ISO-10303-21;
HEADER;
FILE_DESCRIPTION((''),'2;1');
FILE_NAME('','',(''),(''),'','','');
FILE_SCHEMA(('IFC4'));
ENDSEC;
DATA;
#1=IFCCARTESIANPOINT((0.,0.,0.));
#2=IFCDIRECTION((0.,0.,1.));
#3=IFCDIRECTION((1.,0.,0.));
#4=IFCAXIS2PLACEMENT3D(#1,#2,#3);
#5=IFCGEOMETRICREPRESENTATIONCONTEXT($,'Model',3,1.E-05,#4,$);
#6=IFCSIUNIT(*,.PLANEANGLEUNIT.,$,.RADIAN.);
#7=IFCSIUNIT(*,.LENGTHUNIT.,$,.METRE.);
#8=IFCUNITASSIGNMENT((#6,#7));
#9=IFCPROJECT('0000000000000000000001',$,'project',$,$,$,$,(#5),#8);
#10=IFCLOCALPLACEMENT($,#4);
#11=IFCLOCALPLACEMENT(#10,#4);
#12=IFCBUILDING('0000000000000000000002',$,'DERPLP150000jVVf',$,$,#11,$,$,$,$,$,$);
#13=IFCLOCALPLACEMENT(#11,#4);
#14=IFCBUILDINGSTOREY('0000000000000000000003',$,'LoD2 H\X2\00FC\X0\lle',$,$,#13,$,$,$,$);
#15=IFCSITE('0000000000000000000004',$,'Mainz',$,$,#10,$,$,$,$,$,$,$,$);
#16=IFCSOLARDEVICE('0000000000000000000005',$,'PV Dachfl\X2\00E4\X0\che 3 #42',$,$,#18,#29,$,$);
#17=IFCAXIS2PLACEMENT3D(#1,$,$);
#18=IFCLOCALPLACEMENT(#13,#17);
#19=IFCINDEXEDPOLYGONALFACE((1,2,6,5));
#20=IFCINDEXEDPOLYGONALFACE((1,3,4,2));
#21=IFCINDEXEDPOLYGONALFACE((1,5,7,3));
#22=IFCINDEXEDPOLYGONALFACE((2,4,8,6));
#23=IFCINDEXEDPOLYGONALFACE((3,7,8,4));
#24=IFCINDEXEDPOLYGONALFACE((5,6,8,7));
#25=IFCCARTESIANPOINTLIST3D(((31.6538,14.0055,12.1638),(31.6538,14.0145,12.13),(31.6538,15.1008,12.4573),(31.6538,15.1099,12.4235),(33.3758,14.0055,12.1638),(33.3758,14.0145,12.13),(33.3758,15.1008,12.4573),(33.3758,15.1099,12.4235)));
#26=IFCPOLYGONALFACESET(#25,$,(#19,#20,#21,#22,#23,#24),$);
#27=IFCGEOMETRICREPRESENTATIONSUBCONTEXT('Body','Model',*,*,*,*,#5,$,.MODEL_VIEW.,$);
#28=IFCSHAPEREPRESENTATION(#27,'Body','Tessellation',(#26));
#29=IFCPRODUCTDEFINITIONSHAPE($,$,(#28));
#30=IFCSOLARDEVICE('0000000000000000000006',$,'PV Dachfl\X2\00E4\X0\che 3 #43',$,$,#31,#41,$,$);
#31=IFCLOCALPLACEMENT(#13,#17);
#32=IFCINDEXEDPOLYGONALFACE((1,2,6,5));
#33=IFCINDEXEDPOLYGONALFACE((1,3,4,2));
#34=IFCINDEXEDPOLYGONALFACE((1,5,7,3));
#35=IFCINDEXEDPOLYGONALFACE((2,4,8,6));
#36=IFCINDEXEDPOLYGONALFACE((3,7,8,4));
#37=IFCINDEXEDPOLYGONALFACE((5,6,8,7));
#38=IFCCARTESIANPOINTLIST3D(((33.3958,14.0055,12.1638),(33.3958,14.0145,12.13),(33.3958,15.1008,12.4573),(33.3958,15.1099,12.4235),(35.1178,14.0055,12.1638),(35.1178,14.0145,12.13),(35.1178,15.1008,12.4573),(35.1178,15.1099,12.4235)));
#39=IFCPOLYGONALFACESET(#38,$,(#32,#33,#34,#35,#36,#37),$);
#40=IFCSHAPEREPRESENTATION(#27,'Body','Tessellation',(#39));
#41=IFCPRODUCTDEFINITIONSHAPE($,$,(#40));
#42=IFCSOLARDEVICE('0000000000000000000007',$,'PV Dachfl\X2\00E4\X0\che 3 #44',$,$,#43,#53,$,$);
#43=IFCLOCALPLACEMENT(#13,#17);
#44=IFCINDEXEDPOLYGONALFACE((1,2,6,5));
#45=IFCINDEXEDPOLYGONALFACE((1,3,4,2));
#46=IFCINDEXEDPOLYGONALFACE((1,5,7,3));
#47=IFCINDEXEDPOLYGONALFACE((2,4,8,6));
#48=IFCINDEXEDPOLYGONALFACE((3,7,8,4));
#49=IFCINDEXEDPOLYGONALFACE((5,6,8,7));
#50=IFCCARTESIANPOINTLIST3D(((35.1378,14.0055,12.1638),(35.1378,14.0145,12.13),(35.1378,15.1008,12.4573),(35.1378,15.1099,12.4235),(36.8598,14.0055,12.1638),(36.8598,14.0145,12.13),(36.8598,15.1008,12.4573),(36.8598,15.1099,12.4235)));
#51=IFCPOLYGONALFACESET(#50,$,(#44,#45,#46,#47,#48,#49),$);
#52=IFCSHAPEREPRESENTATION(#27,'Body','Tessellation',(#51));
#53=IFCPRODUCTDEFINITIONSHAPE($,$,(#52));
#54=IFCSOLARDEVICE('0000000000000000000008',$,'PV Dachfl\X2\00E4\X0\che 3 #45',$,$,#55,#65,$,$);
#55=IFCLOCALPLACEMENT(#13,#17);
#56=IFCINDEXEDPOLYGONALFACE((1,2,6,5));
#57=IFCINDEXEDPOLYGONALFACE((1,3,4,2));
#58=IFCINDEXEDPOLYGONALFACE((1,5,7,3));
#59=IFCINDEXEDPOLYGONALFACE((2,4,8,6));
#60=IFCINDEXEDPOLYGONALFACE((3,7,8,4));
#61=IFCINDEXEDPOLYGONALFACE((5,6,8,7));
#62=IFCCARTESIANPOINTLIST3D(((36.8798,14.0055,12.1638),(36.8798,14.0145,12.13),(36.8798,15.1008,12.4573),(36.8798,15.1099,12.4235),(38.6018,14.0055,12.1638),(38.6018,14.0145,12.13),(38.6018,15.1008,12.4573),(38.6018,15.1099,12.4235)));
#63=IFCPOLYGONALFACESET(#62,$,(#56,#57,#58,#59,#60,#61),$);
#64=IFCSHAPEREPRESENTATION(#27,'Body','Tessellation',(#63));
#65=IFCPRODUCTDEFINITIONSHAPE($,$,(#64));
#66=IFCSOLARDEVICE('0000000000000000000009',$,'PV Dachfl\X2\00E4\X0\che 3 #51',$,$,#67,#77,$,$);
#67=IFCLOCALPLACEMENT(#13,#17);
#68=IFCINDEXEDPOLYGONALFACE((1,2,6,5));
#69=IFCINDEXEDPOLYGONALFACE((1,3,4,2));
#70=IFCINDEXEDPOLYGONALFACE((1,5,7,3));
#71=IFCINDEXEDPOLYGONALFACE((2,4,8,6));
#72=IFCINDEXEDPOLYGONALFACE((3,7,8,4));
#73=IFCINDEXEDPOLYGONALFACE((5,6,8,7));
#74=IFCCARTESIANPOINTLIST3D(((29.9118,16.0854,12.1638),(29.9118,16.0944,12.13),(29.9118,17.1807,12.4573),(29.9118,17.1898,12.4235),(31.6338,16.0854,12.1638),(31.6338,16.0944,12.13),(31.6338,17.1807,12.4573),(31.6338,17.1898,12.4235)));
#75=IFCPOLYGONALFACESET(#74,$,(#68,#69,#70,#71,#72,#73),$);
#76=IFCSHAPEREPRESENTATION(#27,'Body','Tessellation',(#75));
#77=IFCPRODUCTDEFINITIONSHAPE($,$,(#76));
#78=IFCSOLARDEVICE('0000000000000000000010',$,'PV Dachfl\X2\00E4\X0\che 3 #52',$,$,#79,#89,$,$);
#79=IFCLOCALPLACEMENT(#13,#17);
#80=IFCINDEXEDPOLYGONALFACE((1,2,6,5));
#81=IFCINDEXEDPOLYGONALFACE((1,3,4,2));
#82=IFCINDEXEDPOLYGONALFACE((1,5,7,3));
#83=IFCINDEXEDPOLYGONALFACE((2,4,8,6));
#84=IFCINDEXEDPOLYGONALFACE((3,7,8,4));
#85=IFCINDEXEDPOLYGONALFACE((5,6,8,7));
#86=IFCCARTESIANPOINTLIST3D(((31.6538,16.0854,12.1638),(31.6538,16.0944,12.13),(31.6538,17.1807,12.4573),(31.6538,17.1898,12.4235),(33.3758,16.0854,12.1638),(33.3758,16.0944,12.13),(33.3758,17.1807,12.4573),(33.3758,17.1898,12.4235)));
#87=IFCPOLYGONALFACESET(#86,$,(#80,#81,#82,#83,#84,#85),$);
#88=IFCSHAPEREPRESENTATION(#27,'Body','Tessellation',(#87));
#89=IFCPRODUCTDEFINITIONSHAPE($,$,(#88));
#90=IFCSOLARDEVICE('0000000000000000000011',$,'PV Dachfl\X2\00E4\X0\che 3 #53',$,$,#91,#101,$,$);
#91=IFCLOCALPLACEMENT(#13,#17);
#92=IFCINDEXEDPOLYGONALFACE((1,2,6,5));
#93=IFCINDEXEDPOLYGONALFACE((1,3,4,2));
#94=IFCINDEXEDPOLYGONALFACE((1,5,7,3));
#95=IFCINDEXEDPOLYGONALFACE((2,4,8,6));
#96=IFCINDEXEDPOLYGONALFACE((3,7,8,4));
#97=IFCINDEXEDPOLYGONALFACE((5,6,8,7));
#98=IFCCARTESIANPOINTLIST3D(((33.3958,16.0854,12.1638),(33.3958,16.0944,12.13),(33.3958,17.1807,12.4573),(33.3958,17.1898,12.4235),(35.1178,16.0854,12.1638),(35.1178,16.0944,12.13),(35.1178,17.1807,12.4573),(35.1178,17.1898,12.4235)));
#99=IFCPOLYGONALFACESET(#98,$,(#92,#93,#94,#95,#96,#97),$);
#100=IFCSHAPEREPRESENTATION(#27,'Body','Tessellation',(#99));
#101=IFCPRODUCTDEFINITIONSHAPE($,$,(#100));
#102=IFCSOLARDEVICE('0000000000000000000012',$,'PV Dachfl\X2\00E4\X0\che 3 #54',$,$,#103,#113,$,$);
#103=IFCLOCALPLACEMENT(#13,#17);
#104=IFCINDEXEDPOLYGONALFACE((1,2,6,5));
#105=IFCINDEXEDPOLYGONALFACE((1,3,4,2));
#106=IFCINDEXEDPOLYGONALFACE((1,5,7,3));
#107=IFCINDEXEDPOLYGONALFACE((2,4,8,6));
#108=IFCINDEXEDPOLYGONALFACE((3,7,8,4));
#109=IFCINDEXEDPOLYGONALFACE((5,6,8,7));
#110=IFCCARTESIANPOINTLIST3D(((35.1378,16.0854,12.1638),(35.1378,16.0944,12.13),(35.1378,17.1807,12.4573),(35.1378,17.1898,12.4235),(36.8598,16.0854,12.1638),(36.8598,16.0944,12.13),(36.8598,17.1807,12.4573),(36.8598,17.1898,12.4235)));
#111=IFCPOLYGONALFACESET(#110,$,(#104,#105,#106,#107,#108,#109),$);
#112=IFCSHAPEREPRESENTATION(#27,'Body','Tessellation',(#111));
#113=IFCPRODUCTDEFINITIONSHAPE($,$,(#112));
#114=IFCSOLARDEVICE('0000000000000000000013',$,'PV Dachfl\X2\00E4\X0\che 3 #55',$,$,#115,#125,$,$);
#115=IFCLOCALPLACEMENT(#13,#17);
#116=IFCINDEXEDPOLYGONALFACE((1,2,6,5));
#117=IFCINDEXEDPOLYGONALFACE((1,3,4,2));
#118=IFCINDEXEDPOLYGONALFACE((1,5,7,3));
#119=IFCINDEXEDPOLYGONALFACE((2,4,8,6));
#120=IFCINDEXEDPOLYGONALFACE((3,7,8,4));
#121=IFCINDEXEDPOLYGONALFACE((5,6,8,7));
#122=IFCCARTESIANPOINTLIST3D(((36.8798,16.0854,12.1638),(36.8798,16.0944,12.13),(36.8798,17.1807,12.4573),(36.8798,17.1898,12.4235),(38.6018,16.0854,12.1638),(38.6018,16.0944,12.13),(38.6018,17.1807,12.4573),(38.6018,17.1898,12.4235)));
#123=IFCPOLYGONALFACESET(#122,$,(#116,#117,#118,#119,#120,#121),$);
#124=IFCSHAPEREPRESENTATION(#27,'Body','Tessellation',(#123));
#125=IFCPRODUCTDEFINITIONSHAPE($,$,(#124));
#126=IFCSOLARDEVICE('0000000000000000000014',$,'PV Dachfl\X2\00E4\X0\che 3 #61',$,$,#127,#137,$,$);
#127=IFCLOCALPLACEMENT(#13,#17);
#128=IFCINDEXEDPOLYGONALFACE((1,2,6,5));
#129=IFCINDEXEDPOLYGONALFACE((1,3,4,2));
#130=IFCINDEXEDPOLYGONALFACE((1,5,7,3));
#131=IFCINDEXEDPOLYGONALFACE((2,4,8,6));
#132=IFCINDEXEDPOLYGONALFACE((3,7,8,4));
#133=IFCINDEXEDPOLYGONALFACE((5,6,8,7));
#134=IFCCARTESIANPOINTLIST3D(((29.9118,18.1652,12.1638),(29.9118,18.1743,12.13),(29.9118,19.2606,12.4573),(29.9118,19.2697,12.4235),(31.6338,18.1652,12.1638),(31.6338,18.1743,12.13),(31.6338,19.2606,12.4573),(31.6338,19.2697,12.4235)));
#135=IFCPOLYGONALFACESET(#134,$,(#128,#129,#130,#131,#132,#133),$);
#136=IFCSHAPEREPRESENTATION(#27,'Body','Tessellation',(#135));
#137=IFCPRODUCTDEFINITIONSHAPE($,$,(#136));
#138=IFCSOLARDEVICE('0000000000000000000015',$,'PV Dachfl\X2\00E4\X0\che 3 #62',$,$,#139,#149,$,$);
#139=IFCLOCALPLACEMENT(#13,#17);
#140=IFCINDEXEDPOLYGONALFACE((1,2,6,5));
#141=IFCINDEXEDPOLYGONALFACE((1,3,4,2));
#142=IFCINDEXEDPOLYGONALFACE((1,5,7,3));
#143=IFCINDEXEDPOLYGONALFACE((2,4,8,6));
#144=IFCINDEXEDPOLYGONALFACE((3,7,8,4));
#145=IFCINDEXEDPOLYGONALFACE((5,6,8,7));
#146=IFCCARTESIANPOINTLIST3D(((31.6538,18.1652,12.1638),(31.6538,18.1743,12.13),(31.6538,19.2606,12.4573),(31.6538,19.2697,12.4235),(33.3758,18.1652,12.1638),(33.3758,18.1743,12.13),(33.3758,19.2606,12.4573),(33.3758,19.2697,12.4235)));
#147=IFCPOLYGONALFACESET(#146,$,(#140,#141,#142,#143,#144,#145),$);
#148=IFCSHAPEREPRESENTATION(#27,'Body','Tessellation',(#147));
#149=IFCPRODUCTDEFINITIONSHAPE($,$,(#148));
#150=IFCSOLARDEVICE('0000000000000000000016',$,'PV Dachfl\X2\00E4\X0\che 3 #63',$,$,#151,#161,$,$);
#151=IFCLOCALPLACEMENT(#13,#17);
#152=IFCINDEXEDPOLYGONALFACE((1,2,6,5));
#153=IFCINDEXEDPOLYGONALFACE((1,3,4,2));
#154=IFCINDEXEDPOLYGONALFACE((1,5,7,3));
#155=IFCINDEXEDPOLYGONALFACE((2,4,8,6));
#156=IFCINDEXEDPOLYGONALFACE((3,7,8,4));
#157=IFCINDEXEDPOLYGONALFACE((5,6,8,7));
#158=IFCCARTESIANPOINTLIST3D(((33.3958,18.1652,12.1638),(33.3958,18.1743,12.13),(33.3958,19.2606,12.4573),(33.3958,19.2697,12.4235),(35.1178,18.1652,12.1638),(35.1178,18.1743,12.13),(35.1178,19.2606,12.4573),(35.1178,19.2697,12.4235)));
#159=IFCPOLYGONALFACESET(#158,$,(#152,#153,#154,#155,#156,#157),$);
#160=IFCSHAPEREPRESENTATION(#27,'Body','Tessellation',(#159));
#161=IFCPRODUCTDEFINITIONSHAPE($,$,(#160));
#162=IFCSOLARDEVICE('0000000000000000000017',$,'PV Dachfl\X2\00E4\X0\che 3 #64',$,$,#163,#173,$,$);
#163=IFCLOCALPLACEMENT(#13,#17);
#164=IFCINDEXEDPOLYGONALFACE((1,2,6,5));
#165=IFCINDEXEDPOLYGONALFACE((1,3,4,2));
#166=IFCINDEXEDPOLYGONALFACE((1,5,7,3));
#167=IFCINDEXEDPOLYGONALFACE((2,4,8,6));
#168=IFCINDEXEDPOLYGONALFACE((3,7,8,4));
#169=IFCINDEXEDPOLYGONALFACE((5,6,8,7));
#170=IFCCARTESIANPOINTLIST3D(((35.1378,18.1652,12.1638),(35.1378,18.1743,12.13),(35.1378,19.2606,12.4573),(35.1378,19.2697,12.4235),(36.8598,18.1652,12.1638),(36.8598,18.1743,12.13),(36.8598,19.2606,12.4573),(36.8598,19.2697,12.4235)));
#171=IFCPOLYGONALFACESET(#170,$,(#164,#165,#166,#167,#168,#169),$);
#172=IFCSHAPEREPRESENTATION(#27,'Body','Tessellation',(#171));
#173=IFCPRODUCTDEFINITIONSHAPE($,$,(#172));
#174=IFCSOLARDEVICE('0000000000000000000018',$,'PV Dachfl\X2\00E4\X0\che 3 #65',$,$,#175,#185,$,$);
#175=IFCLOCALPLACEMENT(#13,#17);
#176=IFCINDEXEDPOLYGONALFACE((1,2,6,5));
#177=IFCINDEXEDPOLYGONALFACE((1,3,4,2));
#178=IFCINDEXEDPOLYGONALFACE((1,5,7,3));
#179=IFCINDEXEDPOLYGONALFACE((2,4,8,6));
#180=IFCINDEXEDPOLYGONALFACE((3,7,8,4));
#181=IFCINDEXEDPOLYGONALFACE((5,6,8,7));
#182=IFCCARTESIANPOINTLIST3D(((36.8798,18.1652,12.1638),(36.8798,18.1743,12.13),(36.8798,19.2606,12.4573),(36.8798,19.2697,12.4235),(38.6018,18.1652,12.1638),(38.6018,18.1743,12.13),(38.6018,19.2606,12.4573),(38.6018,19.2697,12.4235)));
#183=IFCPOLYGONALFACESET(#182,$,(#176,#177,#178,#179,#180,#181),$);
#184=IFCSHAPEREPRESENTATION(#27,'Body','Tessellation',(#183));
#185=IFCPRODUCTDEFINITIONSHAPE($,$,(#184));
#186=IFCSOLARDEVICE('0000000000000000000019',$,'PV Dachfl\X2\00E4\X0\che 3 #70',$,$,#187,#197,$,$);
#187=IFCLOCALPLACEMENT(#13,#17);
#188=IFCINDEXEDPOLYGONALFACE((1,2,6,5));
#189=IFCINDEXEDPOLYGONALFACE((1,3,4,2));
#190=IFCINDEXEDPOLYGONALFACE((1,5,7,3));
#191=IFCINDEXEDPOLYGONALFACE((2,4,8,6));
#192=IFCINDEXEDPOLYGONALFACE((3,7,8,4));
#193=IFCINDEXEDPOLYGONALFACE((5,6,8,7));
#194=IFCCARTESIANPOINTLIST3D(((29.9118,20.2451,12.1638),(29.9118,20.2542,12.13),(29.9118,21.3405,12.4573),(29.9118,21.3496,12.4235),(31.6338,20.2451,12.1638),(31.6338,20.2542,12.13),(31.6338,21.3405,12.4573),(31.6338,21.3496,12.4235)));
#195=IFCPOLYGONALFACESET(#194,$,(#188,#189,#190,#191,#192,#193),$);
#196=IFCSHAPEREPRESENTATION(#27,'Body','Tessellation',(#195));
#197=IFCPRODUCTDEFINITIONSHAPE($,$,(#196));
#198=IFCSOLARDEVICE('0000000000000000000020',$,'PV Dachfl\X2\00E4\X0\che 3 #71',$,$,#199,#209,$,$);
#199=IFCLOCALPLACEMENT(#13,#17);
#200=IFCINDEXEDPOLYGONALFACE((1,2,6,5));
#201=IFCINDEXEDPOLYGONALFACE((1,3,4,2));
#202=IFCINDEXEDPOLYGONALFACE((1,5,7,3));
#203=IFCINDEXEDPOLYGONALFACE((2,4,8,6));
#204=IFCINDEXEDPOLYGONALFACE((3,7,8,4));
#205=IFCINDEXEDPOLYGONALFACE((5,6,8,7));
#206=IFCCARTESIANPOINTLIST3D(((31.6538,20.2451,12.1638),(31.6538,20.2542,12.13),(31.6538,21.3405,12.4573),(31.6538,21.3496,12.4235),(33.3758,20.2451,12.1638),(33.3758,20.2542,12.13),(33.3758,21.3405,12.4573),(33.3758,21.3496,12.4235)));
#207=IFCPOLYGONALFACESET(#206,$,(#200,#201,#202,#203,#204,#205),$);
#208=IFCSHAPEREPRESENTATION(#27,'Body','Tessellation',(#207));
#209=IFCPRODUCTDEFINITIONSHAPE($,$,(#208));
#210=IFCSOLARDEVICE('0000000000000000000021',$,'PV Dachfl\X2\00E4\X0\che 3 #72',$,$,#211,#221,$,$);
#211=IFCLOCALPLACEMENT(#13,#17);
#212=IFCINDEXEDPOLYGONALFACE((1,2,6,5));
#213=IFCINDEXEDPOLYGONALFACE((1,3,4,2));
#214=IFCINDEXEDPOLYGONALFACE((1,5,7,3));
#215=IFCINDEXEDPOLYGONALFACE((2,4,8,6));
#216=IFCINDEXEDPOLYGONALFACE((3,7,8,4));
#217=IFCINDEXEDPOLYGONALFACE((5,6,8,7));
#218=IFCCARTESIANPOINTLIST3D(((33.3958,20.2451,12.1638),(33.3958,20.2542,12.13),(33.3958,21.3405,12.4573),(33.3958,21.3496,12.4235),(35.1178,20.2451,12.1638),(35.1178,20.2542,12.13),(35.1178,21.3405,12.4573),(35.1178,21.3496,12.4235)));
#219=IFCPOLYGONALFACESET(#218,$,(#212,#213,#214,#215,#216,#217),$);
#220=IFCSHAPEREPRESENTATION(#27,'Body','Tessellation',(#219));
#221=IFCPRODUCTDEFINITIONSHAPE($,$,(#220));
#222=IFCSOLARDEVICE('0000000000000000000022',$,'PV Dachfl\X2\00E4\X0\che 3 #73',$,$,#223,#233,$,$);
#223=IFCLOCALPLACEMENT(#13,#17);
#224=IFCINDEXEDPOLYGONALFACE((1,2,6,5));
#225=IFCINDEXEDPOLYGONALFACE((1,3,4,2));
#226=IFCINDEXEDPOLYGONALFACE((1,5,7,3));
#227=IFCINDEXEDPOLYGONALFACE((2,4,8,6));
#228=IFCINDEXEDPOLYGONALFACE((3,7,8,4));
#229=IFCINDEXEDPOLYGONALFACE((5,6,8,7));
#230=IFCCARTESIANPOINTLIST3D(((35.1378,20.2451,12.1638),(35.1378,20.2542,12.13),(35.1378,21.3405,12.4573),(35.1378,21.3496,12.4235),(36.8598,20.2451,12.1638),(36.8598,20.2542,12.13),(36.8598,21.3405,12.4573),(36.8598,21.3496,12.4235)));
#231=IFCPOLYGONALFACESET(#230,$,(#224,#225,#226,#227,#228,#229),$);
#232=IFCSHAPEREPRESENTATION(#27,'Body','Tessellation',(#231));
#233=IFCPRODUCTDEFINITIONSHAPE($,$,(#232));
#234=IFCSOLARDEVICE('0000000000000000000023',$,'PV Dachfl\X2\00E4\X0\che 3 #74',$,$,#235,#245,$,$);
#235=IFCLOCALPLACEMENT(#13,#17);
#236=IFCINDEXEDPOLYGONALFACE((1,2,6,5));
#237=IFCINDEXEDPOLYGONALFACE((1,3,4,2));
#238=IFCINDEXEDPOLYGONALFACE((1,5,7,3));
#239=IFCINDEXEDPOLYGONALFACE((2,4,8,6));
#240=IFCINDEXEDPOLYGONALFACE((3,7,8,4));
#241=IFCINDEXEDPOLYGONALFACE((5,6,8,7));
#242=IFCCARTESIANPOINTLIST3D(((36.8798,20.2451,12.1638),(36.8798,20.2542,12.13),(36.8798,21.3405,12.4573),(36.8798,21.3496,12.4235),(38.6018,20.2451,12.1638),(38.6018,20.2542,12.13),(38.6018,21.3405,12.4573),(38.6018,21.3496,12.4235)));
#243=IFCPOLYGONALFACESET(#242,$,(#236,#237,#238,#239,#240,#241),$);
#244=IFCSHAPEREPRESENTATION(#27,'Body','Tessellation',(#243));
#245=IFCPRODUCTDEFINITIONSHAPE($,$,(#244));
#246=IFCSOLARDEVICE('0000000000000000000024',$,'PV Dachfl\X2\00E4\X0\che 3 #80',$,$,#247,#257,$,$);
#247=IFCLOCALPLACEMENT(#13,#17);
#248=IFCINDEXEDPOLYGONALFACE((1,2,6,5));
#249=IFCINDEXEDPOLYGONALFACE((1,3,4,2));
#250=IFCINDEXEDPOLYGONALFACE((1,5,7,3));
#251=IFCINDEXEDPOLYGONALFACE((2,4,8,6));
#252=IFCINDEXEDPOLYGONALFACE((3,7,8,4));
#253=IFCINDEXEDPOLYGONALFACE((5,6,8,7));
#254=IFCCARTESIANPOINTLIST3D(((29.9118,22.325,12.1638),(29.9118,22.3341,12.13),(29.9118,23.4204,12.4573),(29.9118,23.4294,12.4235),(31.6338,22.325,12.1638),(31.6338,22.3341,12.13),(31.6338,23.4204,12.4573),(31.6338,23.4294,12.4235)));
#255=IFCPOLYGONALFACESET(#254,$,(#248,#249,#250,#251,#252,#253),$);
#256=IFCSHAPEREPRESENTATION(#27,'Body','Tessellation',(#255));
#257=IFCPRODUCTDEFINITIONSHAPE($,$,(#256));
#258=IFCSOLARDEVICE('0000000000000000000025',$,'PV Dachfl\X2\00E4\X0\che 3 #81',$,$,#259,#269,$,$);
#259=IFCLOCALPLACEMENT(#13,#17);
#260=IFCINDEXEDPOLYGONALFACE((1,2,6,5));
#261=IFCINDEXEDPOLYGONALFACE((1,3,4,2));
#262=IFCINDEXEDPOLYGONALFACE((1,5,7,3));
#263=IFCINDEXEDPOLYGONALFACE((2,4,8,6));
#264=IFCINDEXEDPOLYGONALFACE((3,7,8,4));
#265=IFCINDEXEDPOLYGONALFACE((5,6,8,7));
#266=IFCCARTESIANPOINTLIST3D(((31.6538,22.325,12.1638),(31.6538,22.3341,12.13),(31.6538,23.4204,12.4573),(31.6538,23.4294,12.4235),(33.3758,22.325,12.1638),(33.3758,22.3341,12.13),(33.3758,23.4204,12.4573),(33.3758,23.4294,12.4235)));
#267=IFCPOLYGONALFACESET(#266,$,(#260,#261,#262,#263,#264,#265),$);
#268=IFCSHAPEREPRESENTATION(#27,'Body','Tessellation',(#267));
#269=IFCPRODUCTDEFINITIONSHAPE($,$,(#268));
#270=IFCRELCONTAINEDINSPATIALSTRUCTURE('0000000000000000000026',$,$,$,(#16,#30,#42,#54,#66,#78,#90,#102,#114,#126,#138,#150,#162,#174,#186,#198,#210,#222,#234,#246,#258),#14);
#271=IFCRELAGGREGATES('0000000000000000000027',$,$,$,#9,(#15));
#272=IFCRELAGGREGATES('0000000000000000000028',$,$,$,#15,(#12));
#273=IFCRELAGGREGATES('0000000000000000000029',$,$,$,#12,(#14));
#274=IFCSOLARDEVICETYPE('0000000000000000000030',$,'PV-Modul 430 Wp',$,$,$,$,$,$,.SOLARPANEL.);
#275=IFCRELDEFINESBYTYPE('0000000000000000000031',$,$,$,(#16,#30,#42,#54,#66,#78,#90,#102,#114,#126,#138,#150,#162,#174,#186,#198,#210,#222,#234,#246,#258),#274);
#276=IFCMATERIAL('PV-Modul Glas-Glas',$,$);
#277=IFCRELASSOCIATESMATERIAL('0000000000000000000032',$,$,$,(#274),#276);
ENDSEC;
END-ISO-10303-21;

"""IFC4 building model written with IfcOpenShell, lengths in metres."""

from ifc_helpers import new_model, si_unit, frame, frame_2d, origin, origin_with_axes, place, context, subcontext, project, spatial, rectangle, extrude, source, transform, mapped, material, type_object, type_shapes, element, save


model = new_model("IFC4")

# Units and contexts
model_context = context("Model", 3, precision=1e-05, world=origin_with_axes())
body_context = subcontext(model_context, "Body", "Model", "MODEL_VIEW")
ifc_project = project(units=[si_unit("PLANEANGLEUNIT", "RADIAN"), si_unit("LENGTHUNIT", "METRE")], contexts=[model_context])

# Site, building, storey
site_placement = place(None, origin_with_axes())
site = spatial("IfcSite", under=ifc_project, at=site_placement, Name="Mainz")
building_placement = place(site_placement, origin_with_axes())
building = spatial("IfcBuilding", under=site, at=building_placement, Name="DERPLP150000jVVf")
storey_placement = place(building_placement, origin_with_axes())
storey = spatial("IfcBuildingStorey", under=building, at=storey_placement, Name="LoD2 Hülle")

# Solar devices
ifc_material = material(Name="PV-Modul Glas-Glas")
solar_device_type = type_object("IfcSolarDeviceType", Name="PV-Modul 430 Wp", PredefinedType="SOLARPANEL", material=ifc_material)
shared_shape = source(origin_with_axes(), body_context, "Body", "SweptSolid", [
    extrude(rectangle(XDim=1.722, YDim=1.134, at=frame_2d((0.861, 0.567))), origin(), (0.0, 0.0, 1.0), 0.035),
])
type_shapes(solar_device_type, [shared_shape])
for number, where, z_axis, x_axis, name in (
    (1, (31.6538, 14.0145, 12.13), (0.0, -0.258819, 0.965926), (1.0, 0.0, 0.0), "PV Dachfläche 3 #42"),
    (2, (33.3958, 14.0145, 12.13), (0.0, -0.258819, 0.965926), (1.0, 0.0, 0.0), "PV Dachfläche 3 #43"),
    (3, (35.1378, 14.0145, 12.13), (0.0, -0.258819, 0.965926), (1.0, 0.0, 0.0), "PV Dachfläche 3 #44"),
    (4, (36.8798, 14.0145, 12.13), (0.0, -0.258819, 0.965926), (1.0, 0.0, 0.0), "PV Dachfläche 3 #45"),
    (5, (29.9118, 16.0944, 12.13), (0.0, -0.258819, 0.965926), (1.0, 0.0, 0.0), "PV Dachfläche 3 #51"),
    (6, (31.6538, 16.0944, 12.13), (0.0, -0.258819, 0.965926), (1.0, 0.0, 0.0), "PV Dachfläche 3 #52"),
    (7, (33.3958, 16.0944, 12.13), (0.0, -0.258819, 0.965926), (1.0, 0.0, 0.0), "PV Dachfläche 3 #53"),
    (8, (35.1378, 16.0944, 12.13), (0.0, -0.258819, 0.965926), (1.0, 0.0, 0.0), "PV Dachfläche 3 #54"),
    (9, (36.8798, 16.0944, 12.13), (0.0, -0.258819, 0.965926), (1.0, 0.0, 0.0), "PV Dachfläche 3 #55"),
    (10, (29.9118, 18.1743, 12.13), (0.0, -0.258819, 0.965926), (1.0, 0.0, 0.0), "PV Dachfläche 3 #61"),
    (11, (31.6538, 18.1743, 12.13), (0.0, -0.258819, 0.965926), (1.0, 0.0, 0.0), "PV Dachfläche 3 #62"),
    (12, (33.3958, 18.1743, 12.13), (0.0, -0.258819, 0.965926), (1.0, 0.0, 0.0), "PV Dachfläche 3 #63"),
    (13, (35.1378, 18.1743, 12.13), (0.0, -0.258819, 0.965926), (1.0, 0.0, 0.0), "PV Dachfläche 3 #64"),
    (14, (36.8798, 18.1743, 12.13), (0.0, -0.258819, 0.965926), (1.0, 0.0, 0.0), "PV Dachfläche 3 #65"),
    (15, (29.9118, 20.2542, 12.13), (0.0, -0.258819, 0.965926), (1.0, 0.0, 0.0), "PV Dachfläche 3 #70"),
    (16, (31.6538, 20.2542, 12.13), (0.0, -0.258819, 0.965926), (1.0, 0.0, 0.0), "PV Dachfläche 3 #71"),
    (17, (33.3958, 20.2542, 12.13), (0.0, -0.258819, 0.965926), (1.0, 0.0, 0.0), "PV Dachfläche 3 #72"),
    (18, (35.1378, 20.2542, 12.13), (0.0, -0.258819, 0.965926), (1.0, 0.0, 0.0), "PV Dachfläche 3 #73"),
    (19, (36.8798, 20.2542, 12.13), (0.0, -0.258819, 0.965926), (1.0, 0.0, 0.0), "PV Dachfläche 3 #74"),
    (20, (29.9118, 22.3341, 12.13), (0.0, -0.258819, 0.965926), (1.0, 0.0, 0.0), "PV Dachfläche 3 #80"),
    (21, (31.6538, 22.3341, 12.13), (0.0, -0.258819, 0.965926), (1.0, 0.0, 0.0), "PV Dachfläche 3 #81"),
):
    element("IfcSolarDevice", number, at=place(storey_placement, frame(where, z_axis=z_axis, x_axis=x_axis)), inside=storey, type_object=solar_device_type, Name=name, context=body_context, shape_type="MappedRepresentation", body=[
        mapped(shared_shape, transform((0.0, 0.0, 0.0), x_axis=(1.0, 0.0, 0.0), y_axis=(0.0, 1.0, 0.0), z_axis=(0.0, 0.0, 1.0), scale=1.0)),
    ])

save(model, "model.ifc")
